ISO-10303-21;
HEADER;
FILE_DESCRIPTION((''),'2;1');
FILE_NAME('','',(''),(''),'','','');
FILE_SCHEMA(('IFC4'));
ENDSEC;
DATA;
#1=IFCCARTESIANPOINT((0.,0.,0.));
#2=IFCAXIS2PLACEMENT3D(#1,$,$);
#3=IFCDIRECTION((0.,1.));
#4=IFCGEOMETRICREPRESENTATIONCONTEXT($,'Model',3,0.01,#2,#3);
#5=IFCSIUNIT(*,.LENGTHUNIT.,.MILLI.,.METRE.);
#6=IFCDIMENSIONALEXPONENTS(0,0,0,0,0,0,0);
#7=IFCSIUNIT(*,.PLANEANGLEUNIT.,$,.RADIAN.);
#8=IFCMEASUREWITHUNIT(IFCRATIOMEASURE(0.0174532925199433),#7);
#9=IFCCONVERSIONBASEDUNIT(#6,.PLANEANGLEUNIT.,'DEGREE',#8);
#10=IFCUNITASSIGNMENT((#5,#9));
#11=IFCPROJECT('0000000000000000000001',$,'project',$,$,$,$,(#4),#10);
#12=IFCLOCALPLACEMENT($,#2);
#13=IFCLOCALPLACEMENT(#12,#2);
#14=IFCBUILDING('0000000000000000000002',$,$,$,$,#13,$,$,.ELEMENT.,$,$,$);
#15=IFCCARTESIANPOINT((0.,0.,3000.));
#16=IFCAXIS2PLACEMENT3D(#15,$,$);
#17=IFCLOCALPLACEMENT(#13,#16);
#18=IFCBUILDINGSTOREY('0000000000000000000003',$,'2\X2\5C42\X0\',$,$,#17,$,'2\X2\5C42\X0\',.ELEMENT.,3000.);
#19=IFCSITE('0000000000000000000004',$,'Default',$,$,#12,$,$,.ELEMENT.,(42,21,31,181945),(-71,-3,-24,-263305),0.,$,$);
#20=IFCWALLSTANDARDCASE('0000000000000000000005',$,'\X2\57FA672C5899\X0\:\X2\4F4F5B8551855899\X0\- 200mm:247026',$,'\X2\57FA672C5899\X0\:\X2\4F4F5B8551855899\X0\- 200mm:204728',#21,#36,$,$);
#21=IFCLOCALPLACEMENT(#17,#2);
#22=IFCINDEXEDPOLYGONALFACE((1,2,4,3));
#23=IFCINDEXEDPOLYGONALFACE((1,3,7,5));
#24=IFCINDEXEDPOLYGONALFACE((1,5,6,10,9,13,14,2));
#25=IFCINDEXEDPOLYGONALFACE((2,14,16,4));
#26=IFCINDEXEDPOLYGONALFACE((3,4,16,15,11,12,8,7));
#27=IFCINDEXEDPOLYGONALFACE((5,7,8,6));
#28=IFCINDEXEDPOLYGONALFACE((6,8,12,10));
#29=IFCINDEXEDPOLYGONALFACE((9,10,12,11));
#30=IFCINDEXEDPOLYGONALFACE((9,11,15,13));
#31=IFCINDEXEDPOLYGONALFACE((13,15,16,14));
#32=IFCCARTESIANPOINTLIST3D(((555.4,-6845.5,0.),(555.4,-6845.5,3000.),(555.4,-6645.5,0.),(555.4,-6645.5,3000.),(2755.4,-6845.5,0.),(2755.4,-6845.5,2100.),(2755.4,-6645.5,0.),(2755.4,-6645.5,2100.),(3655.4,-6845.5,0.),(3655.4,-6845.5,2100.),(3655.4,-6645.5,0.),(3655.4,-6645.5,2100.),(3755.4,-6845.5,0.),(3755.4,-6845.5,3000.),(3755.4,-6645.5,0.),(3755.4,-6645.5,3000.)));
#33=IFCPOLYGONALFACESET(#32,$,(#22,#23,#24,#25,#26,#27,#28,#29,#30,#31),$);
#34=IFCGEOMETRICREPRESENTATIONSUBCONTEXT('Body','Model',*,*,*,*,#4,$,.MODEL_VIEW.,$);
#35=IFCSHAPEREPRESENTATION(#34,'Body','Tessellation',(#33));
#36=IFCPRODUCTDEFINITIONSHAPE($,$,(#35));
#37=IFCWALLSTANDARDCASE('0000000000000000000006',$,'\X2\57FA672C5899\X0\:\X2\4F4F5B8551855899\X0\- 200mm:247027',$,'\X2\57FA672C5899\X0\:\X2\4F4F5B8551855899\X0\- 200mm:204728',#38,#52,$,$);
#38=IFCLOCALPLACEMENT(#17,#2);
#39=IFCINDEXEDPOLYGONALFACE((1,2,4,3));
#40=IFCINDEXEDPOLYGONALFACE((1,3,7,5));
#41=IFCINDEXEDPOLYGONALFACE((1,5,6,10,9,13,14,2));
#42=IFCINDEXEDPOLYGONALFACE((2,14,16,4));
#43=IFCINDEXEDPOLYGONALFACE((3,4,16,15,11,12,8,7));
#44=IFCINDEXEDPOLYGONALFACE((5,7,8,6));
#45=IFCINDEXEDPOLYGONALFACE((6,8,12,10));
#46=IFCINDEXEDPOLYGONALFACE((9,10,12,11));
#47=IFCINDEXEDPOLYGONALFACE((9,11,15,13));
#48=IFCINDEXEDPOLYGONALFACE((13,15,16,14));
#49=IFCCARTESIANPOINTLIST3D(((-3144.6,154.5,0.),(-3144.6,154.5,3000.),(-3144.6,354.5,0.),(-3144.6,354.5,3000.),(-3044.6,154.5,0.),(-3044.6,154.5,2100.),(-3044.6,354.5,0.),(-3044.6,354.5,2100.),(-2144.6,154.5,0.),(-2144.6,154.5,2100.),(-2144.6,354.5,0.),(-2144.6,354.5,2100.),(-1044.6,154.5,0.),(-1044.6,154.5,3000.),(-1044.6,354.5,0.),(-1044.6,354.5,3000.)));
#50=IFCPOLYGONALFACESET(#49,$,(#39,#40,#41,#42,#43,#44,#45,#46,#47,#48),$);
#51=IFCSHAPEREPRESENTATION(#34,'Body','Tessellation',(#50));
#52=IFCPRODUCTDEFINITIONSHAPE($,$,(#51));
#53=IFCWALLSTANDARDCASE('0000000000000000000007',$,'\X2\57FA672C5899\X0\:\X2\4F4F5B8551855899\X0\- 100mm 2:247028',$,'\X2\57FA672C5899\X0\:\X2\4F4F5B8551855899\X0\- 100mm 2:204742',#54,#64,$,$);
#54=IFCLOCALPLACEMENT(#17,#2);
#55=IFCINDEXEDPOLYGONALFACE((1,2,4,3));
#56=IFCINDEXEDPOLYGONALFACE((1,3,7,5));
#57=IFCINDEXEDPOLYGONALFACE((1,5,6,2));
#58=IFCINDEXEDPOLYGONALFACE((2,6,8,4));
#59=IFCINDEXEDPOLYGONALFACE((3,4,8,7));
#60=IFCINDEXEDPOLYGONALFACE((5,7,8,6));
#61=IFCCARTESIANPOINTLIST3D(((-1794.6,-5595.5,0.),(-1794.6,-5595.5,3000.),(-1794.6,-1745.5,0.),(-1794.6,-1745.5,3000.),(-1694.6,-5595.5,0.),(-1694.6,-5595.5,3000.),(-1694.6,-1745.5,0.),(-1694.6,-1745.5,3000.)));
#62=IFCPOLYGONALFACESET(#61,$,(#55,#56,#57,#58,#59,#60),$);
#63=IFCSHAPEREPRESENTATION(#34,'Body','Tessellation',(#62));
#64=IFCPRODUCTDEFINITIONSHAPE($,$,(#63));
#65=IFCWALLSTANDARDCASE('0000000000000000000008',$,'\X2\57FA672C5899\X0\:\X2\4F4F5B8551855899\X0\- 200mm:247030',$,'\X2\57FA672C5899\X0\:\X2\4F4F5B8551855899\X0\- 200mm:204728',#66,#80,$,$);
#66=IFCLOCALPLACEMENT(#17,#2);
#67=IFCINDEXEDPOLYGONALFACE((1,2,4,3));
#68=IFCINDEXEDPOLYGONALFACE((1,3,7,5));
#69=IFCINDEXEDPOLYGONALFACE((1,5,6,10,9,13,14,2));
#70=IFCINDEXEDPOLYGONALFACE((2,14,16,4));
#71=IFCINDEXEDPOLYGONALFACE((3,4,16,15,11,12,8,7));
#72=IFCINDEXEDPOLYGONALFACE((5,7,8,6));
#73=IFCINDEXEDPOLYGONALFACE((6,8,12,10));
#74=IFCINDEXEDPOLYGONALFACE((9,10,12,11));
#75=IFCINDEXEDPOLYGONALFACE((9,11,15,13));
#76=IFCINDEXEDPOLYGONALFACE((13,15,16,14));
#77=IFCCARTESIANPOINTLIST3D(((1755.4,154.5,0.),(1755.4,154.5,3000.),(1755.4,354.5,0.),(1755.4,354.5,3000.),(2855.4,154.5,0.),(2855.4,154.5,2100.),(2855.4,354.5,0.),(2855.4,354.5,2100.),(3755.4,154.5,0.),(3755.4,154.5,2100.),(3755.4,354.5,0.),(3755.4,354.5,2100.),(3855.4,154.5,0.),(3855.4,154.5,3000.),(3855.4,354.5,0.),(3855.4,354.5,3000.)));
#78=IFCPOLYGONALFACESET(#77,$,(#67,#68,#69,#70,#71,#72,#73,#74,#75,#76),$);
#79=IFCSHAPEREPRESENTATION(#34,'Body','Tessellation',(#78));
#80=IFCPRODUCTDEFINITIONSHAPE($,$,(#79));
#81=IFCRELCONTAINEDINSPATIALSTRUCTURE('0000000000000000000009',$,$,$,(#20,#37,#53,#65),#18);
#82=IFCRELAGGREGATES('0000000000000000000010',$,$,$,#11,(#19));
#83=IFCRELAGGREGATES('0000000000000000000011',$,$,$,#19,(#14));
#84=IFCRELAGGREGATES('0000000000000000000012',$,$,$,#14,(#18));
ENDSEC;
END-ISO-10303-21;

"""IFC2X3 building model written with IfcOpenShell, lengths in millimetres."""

from ifc_helpers import new_model, entity, si_unit, converted_unit, direction, frame, frame_2d, origin, place, context, subcontext, project, spatial, polyline, rectangle, extrude, clip, bounded_halfspace, element, save


model = new_model("IFC2X3")

# Units and contexts
model_context = context("Model", 3, precision=0.01, world=origin(), true_north=direction((0.0, 1.0)))
body_context = subcontext(model_context, "Body", "Model", "MODEL_VIEW")
ifc_project = project(units=[si_unit("LENGTHUNIT", "METRE", prefix="MILLI"), converted_unit("PLANEANGLEUNIT", "DEGREE", entity("IfcRatioMeasure", 0.0174532925199433), si_unit("PLANEANGLEUNIT", "RADIAN"), dimensions=[0, 0, 0, 0, 0, 0, 0])], contexts=[model_context])

# Site, building, storey
site_placement = place(None, origin())
site = spatial("IfcSite", under=ifc_project, at=site_placement, Name="Default", CompositionType="ELEMENT", RefLatitude=(42, 21, 31, 181945), RefLongitude=(-71, -3, -24, -263305), RefElevation=0.0)
building_placement = place(site_placement, origin())
building = spatial("IfcBuilding", under=site, at=building_placement, CompositionType="ELEMENT")
storey_placement = place(building_placement, frame((0.0, 0.0, 3000.0)))
storey = spatial("IfcBuildingStorey", under=building, at=storey_placement, Name="2层", LongName="2层", CompositionType="ELEMENT", Elevation=3000.0)

# Walls, openings
wall_1_placement = place(storey_placement, frame((3755.4, -6745.5, 0.0), z_axis=(0.0, 0.0, 1.0), x_axis=(-1.0, 0.0, 0.0)))
wall_1 = element("IfcWallStandardCase", 1, at=wall_1_placement, inside=storey, Name="基本墙:住宅内墙- 200mm:247026", ObjectType="基本墙:住宅内墙- 200mm:204728", context=body_context, shape_type="Clipping", body=[
    clip(clip(extrude(rectangle(XDim=3200.0, YDim=200.0, at=frame_2d((1600.0, 0.0), x_axis=(-1.0, 0.0))), origin(), (0.0, 0.0, 1.0), 3000.0), bounded_halfspace(frame((0.0, -100.0, 0.0), z_axis=(-1.0, 0.0, 0.0), x_axis=(0.0, 0.0, -1.0)), False, frame((0.0, -100.0, 0.0), z_axis=(-1.0, 0.0, 0.0), x_axis=(0.0, 0.0, -1.0)), polyline([(0.0, 0.0), (-3000.0, 0.0), (-3000.0, -200.0), (0.0, -200.0), (0.0, 0.0)]))), bounded_halfspace(frame((3200.0, -100.0, 3000.0), z_axis=(-1.0, 0.0, 0.0), x_axis=(0.0, 0.0, -1.0)), True, frame((3200.0, -100.0, 3000.0), z_axis=(-1.0, 0.0, 0.0), x_axis=(0.0, 0.0, -1.0)), polyline([(0.0, 0.0), (0.0, -200.0), (3000.0, -200.0), (3000.0, 0.0), (0.0, 0.0)]))),
])
opening_1_placement = place(wall_1_placement, frame((100.0, -100.0, 0.0)))
element("IfcOpeningElement", 2, at=opening_1_placement, cuts=wall_1, ObjectType="Opening", context=body_context, shape_type="SweptSolid", body=[
    extrude(rectangle(XDim=2100.0, YDim=900.0, at=frame_2d((1050.0, 450.0), x_axis=(1.0, 0.0))), frame((0.0, 0.0, 0.0), z_axis=(0.0, 1.0, 0.0), x_axis=(0.0, 0.0, 1.0)), (0.0, 0.0, 1.0), 200.0),
])
wall_2_placement = place(storey_placement, frame((-3144.6, 254.5, 0.0)))
wall_2 = element("IfcWallStandardCase", 3, at=wall_2_placement, inside=storey, Name="基本墙:住宅内墙- 200mm:247027", ObjectType="基本墙:住宅内墙- 200mm:204728", context=body_context, shape_type="SweptSolid", body=[
    extrude(rectangle(XDim=2100.0, YDim=200.0, at=frame_2d((1050.0, 0.0), x_axis=(-1.0, 0.0))), origin(), (0.0, 0.0, 1.0), 3000.0),
])
opening_2_placement = place(wall_2_placement, frame((100.0, -100.0, 0.0)))
element("IfcOpeningElement", 4, at=opening_2_placement, cuts=wall_2, ObjectType="Opening", context=body_context, shape_type="SweptSolid", body=[
    extrude(rectangle(XDim=2100.0, YDim=900.0, at=frame_2d((1050.0, 450.0), x_axis=(1.0, 0.0))), frame((0.0, 0.0, 0.0), z_axis=(0.0, 1.0, 0.0), x_axis=(0.0, 0.0, 1.0)), (0.0, 0.0, 1.0), 200.0),
])

# Wall
wall_3_placement = place(storey_placement, frame((-1744.6, -1745.5, 0.0), z_axis=(0.0, 0.0, 1.0), x_axis=(0.0, -1.0, 0.0)))
element("IfcWallStandardCase", 5, at=wall_3_placement, inside=storey, Name="基本墙:住宅内墙- 100mm 2:247028", ObjectType="基本墙:住宅内墙- 100mm 2:204742", context=body_context, shape_type="SweptSolid", body=[
    extrude(rectangle(XDim=3850.0, YDim=100.0, at=frame_2d((1925.0, 0.0), x_axis=(-1.0, 0.0))), origin(), (0.0, 0.0, 1.0), 3000.0),
])

# Wall, opening
wall_4_placement = place(storey_placement, frame((3855.4, 254.5, 0.0), z_axis=(0.0, 0.0, 1.0), x_axis=(-1.0, 0.0, 0.0)))
wall_4 = element("IfcWallStandardCase", 6, at=wall_4_placement, inside=storey, Name="基本墙:住宅内墙- 200mm:247030", ObjectType="基本墙:住宅内墙- 200mm:204728", context=body_context, shape_type="SweptSolid", body=[
    extrude(rectangle(XDim=2100.0, YDim=200.0, at=frame_2d((1050.0, 0.0), x_axis=(-1.0, 0.0))), origin(), (0.0, 0.0, 1.0), 3000.0),
])
opening_3_placement = place(wall_4_placement, frame((1000.0, 100.0, 0.0)))
element("IfcOpeningElement", 7, at=opening_3_placement, cuts=wall_4, ObjectType="Opening", context=body_context, shape_type="SweptSolid", body=[
    extrude(rectangle(XDim=2100.0, YDim=900.0, at=frame_2d((1050.0, 450.0), x_axis=(1.0, 0.0))), frame((0.0, 0.0, 0.0), z_axis=(0.0, -1.0, 0.0), x_axis=(0.0, 0.0, 1.0)), (0.0, 0.0, 1.0), 200.0),
])

save(model, "model.ifc")
